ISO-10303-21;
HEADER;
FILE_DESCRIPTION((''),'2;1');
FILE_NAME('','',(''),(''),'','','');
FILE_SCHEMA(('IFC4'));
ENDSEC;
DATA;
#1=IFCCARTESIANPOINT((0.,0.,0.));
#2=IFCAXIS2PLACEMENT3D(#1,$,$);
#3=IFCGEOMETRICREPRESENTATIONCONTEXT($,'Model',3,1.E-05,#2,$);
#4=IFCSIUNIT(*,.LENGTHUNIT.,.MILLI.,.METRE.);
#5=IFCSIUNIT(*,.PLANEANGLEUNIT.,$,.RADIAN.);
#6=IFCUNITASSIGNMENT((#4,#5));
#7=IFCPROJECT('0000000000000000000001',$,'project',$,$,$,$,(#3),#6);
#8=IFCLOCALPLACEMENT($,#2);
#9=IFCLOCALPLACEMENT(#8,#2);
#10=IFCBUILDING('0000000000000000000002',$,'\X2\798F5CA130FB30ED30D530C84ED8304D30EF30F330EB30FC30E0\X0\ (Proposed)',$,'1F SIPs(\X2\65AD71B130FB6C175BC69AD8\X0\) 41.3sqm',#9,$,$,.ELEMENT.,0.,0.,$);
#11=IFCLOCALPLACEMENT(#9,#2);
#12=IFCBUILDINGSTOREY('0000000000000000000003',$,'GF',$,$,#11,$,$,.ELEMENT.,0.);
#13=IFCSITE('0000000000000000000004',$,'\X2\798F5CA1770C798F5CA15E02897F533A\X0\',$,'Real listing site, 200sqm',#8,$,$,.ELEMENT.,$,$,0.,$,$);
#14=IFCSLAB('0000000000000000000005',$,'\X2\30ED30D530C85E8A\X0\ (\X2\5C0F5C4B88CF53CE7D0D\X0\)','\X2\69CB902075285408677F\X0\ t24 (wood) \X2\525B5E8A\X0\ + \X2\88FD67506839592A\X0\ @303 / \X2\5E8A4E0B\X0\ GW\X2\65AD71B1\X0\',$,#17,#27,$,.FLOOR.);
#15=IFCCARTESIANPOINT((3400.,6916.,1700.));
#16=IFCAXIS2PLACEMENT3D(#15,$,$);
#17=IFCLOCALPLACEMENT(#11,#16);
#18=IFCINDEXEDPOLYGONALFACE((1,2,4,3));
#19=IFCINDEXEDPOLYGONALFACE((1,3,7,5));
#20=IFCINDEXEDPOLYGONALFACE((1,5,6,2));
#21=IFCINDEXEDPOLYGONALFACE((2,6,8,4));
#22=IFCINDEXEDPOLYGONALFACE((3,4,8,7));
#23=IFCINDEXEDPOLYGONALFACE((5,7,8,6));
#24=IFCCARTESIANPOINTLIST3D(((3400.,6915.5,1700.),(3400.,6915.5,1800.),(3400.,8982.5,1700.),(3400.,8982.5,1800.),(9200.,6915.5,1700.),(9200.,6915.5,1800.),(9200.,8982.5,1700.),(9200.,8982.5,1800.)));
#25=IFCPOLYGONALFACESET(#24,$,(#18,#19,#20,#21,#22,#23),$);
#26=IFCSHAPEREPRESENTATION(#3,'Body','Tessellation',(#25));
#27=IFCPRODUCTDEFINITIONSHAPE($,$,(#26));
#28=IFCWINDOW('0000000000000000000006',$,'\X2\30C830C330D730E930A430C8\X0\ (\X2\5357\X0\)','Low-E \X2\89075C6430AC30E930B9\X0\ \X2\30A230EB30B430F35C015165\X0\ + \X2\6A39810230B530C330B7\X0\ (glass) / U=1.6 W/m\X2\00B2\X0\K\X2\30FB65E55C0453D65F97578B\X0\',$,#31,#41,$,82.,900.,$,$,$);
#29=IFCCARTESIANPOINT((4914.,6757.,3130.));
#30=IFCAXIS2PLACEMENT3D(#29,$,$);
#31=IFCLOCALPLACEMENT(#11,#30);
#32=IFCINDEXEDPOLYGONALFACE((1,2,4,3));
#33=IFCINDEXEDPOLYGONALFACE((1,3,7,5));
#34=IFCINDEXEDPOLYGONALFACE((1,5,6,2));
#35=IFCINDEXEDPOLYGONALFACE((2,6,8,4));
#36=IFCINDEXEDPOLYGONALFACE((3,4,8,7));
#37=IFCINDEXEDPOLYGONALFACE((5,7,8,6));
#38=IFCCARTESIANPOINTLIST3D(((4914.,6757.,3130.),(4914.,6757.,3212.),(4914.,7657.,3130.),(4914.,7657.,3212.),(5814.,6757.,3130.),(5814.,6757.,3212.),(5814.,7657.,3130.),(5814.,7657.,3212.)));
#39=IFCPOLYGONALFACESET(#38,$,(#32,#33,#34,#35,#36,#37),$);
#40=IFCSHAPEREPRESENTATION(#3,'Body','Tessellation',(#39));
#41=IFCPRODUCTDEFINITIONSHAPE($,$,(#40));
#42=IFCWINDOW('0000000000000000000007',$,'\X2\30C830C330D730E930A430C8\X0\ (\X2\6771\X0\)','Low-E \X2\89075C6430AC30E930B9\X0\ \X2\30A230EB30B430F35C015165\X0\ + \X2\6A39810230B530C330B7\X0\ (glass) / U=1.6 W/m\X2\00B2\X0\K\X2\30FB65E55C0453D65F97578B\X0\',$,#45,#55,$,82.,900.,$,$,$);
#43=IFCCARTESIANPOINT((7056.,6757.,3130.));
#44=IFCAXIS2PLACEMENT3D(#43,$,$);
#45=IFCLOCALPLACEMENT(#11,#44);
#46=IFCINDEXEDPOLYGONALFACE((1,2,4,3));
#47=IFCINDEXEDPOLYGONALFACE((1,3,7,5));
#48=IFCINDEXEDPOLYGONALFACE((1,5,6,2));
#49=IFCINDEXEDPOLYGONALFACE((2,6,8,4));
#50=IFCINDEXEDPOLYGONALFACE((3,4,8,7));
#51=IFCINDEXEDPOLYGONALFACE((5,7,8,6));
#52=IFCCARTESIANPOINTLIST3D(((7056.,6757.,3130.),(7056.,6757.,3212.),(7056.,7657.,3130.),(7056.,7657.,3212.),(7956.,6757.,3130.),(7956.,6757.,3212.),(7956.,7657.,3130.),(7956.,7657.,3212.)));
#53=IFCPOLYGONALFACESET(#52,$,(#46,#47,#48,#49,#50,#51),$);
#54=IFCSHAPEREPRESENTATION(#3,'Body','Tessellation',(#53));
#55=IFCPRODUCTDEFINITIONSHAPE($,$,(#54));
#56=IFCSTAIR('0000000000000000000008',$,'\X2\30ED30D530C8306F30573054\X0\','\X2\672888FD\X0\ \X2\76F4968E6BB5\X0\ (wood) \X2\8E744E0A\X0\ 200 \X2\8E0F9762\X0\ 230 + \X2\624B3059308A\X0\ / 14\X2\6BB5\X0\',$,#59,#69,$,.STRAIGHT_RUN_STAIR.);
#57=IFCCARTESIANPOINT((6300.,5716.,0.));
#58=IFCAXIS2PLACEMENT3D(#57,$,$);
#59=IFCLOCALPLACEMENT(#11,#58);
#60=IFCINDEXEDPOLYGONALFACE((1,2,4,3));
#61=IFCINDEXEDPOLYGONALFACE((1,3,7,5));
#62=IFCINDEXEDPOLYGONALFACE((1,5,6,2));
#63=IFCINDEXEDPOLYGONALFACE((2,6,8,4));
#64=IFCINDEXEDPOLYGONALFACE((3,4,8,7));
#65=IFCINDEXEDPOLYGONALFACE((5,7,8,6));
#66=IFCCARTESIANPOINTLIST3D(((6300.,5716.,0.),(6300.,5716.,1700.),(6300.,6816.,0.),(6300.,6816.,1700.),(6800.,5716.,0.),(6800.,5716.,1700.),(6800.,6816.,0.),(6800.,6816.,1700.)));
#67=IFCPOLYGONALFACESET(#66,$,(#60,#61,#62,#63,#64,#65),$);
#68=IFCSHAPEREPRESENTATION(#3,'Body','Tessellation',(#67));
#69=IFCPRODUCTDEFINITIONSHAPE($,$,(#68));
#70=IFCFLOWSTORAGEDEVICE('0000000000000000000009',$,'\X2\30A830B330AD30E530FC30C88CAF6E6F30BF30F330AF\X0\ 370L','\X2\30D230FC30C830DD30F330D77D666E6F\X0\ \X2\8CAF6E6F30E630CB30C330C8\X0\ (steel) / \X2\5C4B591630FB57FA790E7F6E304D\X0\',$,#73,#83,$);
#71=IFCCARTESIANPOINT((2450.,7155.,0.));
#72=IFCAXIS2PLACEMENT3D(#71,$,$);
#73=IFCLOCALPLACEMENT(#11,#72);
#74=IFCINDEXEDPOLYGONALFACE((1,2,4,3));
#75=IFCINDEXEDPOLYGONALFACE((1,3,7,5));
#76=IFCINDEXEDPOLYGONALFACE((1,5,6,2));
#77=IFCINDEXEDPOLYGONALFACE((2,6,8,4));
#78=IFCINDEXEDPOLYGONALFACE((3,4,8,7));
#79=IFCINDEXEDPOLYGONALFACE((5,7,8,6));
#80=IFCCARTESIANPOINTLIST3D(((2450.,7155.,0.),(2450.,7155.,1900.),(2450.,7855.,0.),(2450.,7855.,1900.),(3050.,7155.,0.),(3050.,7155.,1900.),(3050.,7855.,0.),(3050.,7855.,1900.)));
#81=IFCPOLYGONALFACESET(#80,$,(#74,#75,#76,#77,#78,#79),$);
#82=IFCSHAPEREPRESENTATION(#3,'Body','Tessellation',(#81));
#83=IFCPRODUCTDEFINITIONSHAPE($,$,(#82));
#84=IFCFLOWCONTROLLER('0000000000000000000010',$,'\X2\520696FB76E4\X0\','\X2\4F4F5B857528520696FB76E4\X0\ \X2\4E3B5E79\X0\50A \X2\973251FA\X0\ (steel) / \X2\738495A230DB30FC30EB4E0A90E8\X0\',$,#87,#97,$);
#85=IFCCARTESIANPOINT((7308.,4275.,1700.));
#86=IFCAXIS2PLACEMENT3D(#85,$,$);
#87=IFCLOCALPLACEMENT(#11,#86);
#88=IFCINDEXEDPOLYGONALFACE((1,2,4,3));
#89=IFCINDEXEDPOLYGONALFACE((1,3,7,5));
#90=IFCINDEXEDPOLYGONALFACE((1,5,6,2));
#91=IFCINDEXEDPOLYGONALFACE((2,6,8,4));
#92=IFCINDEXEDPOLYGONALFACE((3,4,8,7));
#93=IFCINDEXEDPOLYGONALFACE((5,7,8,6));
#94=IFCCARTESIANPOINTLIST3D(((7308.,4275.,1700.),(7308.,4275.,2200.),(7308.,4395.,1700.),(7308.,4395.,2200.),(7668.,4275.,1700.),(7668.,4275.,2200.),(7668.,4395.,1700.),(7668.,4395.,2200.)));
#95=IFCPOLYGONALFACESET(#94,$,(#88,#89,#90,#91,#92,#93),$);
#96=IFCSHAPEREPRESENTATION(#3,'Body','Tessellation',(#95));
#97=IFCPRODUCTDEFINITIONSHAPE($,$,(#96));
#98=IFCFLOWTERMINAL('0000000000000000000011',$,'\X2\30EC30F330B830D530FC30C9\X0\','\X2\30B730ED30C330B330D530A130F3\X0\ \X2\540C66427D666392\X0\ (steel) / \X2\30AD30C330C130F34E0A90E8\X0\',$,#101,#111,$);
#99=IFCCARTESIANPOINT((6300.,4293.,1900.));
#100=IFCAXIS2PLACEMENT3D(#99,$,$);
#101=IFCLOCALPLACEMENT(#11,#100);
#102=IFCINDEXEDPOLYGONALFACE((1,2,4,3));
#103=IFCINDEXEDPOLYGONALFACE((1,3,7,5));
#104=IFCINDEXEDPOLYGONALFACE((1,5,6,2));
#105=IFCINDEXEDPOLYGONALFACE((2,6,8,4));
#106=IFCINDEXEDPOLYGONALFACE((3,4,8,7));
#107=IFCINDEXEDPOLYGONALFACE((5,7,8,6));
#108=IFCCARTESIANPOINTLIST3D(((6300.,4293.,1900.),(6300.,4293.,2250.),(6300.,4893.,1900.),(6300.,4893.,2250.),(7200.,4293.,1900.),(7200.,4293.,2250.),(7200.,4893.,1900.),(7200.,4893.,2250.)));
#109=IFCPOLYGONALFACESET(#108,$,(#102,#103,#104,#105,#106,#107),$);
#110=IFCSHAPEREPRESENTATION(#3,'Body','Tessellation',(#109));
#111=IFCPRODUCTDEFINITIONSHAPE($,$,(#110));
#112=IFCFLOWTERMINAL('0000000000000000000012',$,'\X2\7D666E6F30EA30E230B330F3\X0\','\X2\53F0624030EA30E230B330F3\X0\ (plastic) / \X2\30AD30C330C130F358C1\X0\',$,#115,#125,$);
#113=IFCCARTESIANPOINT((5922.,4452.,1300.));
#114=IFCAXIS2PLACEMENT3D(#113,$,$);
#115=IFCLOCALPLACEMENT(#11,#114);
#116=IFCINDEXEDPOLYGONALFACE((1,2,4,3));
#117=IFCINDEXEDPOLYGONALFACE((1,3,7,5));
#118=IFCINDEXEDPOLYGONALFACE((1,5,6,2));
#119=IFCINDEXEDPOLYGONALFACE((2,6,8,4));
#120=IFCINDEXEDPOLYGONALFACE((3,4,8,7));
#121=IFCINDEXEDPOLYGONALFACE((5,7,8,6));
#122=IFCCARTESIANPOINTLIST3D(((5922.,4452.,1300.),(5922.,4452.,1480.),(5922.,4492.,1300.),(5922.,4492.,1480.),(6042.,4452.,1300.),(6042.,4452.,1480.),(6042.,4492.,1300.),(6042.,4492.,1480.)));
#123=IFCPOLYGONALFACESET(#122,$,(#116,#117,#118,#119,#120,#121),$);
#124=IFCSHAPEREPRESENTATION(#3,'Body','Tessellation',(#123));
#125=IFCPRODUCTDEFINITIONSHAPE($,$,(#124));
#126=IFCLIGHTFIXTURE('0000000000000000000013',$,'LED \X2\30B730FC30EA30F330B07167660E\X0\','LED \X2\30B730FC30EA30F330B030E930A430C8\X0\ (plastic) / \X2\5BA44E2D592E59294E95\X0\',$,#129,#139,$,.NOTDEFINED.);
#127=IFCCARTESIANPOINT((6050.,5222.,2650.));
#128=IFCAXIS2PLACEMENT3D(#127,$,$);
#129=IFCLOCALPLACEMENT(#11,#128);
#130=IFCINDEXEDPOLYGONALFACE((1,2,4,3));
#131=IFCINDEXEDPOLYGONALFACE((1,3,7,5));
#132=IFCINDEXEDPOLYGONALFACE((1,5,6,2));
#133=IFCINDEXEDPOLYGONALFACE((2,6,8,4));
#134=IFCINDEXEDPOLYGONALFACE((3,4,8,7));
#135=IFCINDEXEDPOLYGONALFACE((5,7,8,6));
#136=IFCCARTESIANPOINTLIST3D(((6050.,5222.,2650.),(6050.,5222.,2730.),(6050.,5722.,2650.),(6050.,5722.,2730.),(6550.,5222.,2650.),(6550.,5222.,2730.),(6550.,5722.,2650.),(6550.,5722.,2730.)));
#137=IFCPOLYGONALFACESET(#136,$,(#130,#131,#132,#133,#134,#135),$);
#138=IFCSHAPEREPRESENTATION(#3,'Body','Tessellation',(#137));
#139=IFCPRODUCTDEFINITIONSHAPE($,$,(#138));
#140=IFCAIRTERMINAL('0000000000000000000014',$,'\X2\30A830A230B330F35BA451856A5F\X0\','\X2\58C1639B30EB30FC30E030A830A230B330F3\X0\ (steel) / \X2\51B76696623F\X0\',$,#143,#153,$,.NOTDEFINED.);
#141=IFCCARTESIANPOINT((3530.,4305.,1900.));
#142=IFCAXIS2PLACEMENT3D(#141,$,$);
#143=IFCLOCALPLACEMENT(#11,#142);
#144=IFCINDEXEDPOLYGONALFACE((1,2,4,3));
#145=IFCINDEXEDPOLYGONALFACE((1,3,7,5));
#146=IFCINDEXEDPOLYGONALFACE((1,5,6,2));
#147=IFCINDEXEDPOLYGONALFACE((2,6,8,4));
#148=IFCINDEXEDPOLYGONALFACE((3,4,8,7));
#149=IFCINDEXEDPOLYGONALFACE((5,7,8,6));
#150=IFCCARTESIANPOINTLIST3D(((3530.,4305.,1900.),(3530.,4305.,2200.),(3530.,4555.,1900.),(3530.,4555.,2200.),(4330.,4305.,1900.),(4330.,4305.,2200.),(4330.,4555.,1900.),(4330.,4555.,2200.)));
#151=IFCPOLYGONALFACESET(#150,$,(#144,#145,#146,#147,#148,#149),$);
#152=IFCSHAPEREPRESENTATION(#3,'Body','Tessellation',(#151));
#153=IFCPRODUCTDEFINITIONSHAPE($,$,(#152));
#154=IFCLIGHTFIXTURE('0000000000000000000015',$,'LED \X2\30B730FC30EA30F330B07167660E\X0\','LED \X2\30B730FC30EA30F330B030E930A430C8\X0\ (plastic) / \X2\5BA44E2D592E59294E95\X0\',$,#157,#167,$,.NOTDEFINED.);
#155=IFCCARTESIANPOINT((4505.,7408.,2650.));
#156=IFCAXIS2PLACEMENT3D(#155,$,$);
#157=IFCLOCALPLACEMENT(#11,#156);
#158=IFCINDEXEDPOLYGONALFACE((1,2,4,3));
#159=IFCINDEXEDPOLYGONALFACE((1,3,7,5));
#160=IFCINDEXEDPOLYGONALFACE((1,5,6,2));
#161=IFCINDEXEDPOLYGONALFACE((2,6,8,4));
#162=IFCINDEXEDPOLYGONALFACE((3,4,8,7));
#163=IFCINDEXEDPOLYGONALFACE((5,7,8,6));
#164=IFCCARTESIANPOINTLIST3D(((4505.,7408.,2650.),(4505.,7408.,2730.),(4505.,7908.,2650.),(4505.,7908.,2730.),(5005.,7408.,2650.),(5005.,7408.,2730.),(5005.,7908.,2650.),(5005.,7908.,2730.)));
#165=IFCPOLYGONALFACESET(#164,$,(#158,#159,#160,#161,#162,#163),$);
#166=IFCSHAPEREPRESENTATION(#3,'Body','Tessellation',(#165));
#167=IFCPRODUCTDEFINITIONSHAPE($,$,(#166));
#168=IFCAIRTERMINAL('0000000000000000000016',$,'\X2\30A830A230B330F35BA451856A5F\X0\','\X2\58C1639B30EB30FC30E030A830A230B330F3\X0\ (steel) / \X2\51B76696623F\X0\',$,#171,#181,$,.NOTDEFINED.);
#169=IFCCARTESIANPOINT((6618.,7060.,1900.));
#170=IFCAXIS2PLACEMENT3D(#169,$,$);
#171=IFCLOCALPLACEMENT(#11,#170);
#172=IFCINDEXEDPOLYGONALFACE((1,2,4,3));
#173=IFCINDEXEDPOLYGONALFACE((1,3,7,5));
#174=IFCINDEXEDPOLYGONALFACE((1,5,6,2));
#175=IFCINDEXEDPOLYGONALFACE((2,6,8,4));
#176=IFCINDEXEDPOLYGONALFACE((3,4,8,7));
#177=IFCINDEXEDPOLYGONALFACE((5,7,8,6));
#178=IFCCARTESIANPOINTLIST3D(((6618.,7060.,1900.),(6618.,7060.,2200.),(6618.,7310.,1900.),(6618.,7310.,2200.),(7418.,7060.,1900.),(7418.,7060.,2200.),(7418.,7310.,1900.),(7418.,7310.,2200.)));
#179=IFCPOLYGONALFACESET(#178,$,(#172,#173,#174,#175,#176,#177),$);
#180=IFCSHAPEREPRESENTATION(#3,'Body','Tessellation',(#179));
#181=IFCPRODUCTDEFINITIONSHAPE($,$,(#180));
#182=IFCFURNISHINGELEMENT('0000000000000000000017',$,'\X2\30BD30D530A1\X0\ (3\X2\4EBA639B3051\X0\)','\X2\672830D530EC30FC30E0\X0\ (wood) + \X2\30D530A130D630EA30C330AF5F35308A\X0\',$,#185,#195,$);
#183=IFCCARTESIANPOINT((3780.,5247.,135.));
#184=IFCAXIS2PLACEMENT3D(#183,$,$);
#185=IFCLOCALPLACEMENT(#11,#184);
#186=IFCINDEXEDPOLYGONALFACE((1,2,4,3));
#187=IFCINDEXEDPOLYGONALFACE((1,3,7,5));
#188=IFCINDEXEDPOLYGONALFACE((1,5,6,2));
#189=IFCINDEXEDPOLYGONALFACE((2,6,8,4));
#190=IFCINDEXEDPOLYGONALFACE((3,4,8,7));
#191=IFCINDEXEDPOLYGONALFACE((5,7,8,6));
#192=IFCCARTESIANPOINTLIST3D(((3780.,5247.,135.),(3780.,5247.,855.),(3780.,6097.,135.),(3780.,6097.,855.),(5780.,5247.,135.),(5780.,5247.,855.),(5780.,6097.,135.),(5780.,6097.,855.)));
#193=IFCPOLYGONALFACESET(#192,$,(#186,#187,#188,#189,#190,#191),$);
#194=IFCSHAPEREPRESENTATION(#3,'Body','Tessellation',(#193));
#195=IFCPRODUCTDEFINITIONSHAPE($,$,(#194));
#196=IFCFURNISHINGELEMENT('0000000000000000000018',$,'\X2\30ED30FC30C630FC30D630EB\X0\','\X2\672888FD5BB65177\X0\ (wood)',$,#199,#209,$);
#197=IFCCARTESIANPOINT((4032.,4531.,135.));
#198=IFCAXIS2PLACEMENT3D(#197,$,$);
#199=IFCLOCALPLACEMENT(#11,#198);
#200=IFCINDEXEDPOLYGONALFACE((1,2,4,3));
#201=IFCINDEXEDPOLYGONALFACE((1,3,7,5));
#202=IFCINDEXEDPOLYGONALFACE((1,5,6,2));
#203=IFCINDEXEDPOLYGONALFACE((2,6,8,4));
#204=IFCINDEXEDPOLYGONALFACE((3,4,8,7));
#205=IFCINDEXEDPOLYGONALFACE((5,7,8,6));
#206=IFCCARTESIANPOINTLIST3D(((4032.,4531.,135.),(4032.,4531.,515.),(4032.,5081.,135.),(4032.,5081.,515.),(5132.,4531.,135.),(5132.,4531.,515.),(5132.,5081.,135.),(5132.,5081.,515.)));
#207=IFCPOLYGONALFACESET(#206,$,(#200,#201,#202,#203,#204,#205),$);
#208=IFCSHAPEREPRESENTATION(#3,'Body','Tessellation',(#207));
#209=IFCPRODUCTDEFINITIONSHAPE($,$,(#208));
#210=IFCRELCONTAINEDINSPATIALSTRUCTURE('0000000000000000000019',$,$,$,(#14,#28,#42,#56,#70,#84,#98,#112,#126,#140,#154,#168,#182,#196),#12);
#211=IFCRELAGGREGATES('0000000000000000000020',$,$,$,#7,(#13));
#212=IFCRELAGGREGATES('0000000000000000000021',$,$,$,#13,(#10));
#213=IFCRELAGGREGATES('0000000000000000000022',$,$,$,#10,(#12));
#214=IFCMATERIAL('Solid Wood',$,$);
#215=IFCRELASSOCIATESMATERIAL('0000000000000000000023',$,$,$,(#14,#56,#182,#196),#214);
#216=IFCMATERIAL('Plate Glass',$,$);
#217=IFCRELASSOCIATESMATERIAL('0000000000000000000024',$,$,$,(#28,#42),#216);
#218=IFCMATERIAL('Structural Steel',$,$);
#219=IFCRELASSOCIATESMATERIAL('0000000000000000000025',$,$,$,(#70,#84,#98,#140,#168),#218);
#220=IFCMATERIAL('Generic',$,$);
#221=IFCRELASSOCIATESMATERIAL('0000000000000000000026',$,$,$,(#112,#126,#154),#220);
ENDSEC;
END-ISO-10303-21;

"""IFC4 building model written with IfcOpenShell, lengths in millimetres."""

from ifc_helpers import new_model, si_unit, frame, frame_2d, origin, place, context, project, spatial, rectangle, extrude, material, element, save


model = new_model("IFC4")

# Units and contexts
model_context = context("Model", 3, precision=1e-05, world=origin())
ifc_project = project(units=[si_unit("LENGTHUNIT", "METRE", prefix="MILLI"), si_unit("PLANEANGLEUNIT", "RADIAN")], contexts=[model_context])

# Site, building, storey
site_placement = place(None, origin())
site = spatial("IfcSite", under=ifc_project, at=site_placement, Name="福岡県福岡市西区", ObjectType="Real listing site, 200sqm", CompositionType="ELEMENT", RefElevation=0.0)
building_placement = place(site_placement, origin())
building = spatial("IfcBuilding", under=site, at=building_placement, Name="福岡・ロフト付きワンルーム (Proposed)", ObjectType="1F SIPs(断熱・気密高) 41.3sqm", CompositionType="ELEMENT", ElevationOfRefHeight=0.0, ElevationOfTerrain=0.0)
storey_placement = place(building_placement, origin())
storey = spatial("IfcBuildingStorey", under=building, at=storey_placement, Name="GF", CompositionType="ELEMENT", Elevation=0.0)

# Shared definitions
ifc_material_1 = material(Name="Solid Wood")

# Slab
slab_placement = place(storey_placement, frame((3400.0, 6916.0, 1700.0)))
element("IfcSlab", 1, at=slab_placement, inside=storey, material=ifc_material_1, Name="ロフト床 (小屋裏収納)", Description="構造用合板 t24 (wood) 剛床 + 製材根太 @303 / 床下 GW断熱", PredefinedType="FLOOR", context=model_context, shape_type="SweptSolid", body=[
    extrude(rectangle(XDim=5800.0, YDim=2067.0, at=frame_2d((2900.0, 1033.0))), frame((3400.0, 6916.0, 1700.0)), (0.0, 0.0, 1.0), 100.0),
])

# Windows
ifc_material_2 = material(Name="Plate Glass")
window_1_placement = place(storey_placement, frame((4914.0, 6757.0, 3130.0)))
element("IfcWindow", 2, at=window_1_placement, inside=storey, material=ifc_material_2, Name="トップライト (南)", Description="Low-E 複層ガラス アルゴン封入 + 樹脂サッシ (glass) / U=1.6 W/m²K・日射取得型", OverallHeight=82.0, OverallWidth=900.0, context=model_context, shape_type="SweptSolid", body=[
    extrude(rectangle(XDim=900.0, YDim=900.0, at=frame_2d((450.0, 450.0))), frame((4914.0, 6757.0, 3130.0)), (0.0, 0.0, 1.0), 82.0),
])
window_2_placement = place(storey_placement, frame((7056.0, 6757.0, 3130.0)))
element("IfcWindow", 3, at=window_2_placement, inside=storey, material=ifc_material_2, Name="トップライト (東)", Description="Low-E 複層ガラス アルゴン封入 + 樹脂サッシ (glass) / U=1.6 W/m²K・日射取得型", OverallHeight=82.0, OverallWidth=900.0, context=model_context, shape_type="SweptSolid", body=[
    extrude(rectangle(XDim=900.0, YDim=900.0, at=frame_2d((450.0, 450.0))), frame((7056.0, 6757.0, 3130.0)), (0.0, 0.0, 1.0), 82.0),
])

# Stair
stair_placement = place(storey_placement, frame((6300.0, 5716.0, 0.0)))
element("IfcStair", 4, at=stair_placement, inside=storey, material=ifc_material_1, Name="ロフトはしご", Description="木製 直階段 (wood) 蹴上 200 踏面 230 + 手すり / 14段", PredefinedType="STRAIGHT_RUN_STAIR", context=model_context, shape_type="SweptSolid", body=[
    extrude(rectangle(XDim=500.0, YDim=1100.0, at=frame_2d((250.0, 550.0))), frame((6300.0, 5716.0, 0.0)), (0.0, 0.0, 1.0), 1700.0),
])

# Flow storage device
ifc_material_3 = material(Name="Structural Steel")
flow_storage_device_placement = place(storey_placement, frame((2450.0, 7155.0, 0.0)))
element("IfcFlowStorageDevice", 5, at=flow_storage_device_placement, inside=storey, material=ifc_material_3, Name="エコキュート貯湯タンク 370L", Description="ヒートポンプ給湯 貯湯ユニット (steel) / 屋外・基礎置き", context=model_context, shape_type="SweptSolid", body=[
    extrude(rectangle(XDim=600.0, YDim=700.0, at=frame_2d((300.0, 350.0))), frame((2450.0, 7155.0, 0.0)), (0.0, 0.0, 1.0), 1900.0),
])

# Flow controller
flow_controller_placement = place(storey_placement, frame((7308.0, 4275.0, 1700.0)))
element("IfcFlowController", 6, at=flow_controller_placement, inside=storey, material=ifc_material_3, Name="分電盤", Description="住宅用分電盤 主幹50A 露出 (steel) / 玄関ホール上部", context=model_context, shape_type="SweptSolid", body=[
    extrude(rectangle(XDim=360.0, YDim=120.0, at=frame_2d((180.0, 60.0))), frame((7308.0, 4275.0, 1700.0)), (0.0, 0.0, 1.0), 500.0),
])

# Flow terminals
flow_terminal_1_placement = place(storey_placement, frame((6300.0, 4293.0, 1900.0)))
element("IfcFlowTerminal", 7, at=flow_terminal_1_placement, inside=storey, material=ifc_material_3, Name="レンジフード", Description="シロッコファン 同時給排 (steel) / キッチン上部", context=model_context, shape_type="SweptSolid", body=[
    extrude(rectangle(XDim=900.0, YDim=600.0, at=frame_2d((450.0, 300.0))), frame((6300.0, 4293.0, 1900.0)), (0.0, 0.0, 1.0), 350.0),
])
ifc_material_4 = material(Name="Generic")
flow_terminal_2_placement = place(storey_placement, frame((5922.0, 4452.0, 1300.0)))
element("IfcFlowTerminal", 8, at=flow_terminal_2_placement, inside=storey, material=ifc_material_4, Name="給湯リモコン", Description="台所リモコン (plastic) / キッチン壁", context=model_context, shape_type="SweptSolid", body=[
    extrude(rectangle(XDim=120.0, YDim=40.0, at=frame_2d((60.0, 20.0))), frame((5922.0, 4452.0, 1300.0)), (0.0, 0.0, 1.0), 180.0),
])

# Light fixture
light_fixture_1_placement = place(storey_placement, frame((6050.0, 5222.0, 2650.0)))
element("IfcLightFixture", 9, at=light_fixture_1_placement, inside=storey, material=ifc_material_4, Name="LED シーリング照明", Description="LED シーリングライト (plastic) / 室中央天井", PredefinedType="NOTDEFINED", context=model_context, shape_type="SweptSolid", body=[
    extrude(rectangle(XDim=500.0, YDim=500.0, at=frame_2d((250.0, 250.0))), frame((6050.0, 5222.0, 2650.0)), (0.0, 0.0, 1.0), 80.0),
])

# Air terminal
air_terminal_1_placement = place(storey_placement, frame((3530.0, 4305.0, 1900.0)))
element("IfcAirTerminal", 10, at=air_terminal_1_placement, inside=storey, material=ifc_material_3, Name="エアコン室内機", Description="壁掛ルームエアコン (steel) / 冷暖房", PredefinedType="NOTDEFINED", context=model_context, shape_type="SweptSolid", body=[
    extrude(rectangle(XDim=800.0, YDim=250.0, at=frame_2d((400.0, 125.0))), frame((3530.0, 4305.0, 1900.0)), (0.0, 0.0, 1.0), 300.0),
])

# Light fixture
light_fixture_2_placement = place(storey_placement, frame((4505.0, 7408.0, 2650.0)))
element("IfcLightFixture", 11, at=light_fixture_2_placement, inside=storey, material=ifc_material_4, Name="LED シーリング照明", Description="LED シーリングライト (plastic) / 室中央天井", PredefinedType="NOTDEFINED", context=model_context, shape_type="SweptSolid", body=[
    extrude(rectangle(XDim=500.0, YDim=500.0, at=frame_2d((250.0, 250.0))), frame((4505.0, 7408.0, 2650.0)), (0.0, 0.0, 1.0), 80.0),
])

# Air terminal
air_terminal_2_placement = place(storey_placement, frame((6618.0, 7060.0, 1900.0)))
element("IfcAirTerminal", 12, at=air_terminal_2_placement, inside=storey, material=ifc_material_3, Name="エアコン室内機", Description="壁掛ルームエアコン (steel) / 冷暖房", PredefinedType="NOTDEFINED", context=model_context, shape_type="SweptSolid", body=[
    extrude(rectangle(XDim=800.0, YDim=250.0, at=frame_2d((400.0, 125.0))), frame((6618.0, 7060.0, 1900.0)), (0.0, 0.0, 1.0), 300.0),
])

# Furnishing elements
furnishing_1_placement = place(storey_placement, frame((3780.0, 5247.0, 135.0)))
element("IfcFurnishingElement", 13, at=furnishing_1_placement, inside=storey, material=ifc_material_1, Name="ソファ (3人掛け)", Description="木フレーム (wood) + ファブリック張り", context=model_context, shape_type="SweptSolid", body=[
    extrude(rectangle(XDim=2000.0, YDim=850.0, at=frame_2d((1000.0, 425.0))), frame((3780.0, 5247.0, 135.0)), (0.0, 0.0, 1.0), 720.0),
])
furnishing_2_placement = place(storey_placement, frame((4032.0, 4531.0, 135.0)))
element("IfcFurnishingElement", 14, at=furnishing_2_placement, inside=storey, material=ifc_material_1, Name="ローテーブル", Description="木製家具 (wood)", context=model_context, shape_type="SweptSolid", body=[
    extrude(rectangle(XDim=1100.0, YDim=550.0, at=frame_2d((550.0, 275.0))), frame((4032.0, 4531.0, 135.0)), (0.0, 0.0, 1.0), 380.0),
])

save(model, "model.ifc")
